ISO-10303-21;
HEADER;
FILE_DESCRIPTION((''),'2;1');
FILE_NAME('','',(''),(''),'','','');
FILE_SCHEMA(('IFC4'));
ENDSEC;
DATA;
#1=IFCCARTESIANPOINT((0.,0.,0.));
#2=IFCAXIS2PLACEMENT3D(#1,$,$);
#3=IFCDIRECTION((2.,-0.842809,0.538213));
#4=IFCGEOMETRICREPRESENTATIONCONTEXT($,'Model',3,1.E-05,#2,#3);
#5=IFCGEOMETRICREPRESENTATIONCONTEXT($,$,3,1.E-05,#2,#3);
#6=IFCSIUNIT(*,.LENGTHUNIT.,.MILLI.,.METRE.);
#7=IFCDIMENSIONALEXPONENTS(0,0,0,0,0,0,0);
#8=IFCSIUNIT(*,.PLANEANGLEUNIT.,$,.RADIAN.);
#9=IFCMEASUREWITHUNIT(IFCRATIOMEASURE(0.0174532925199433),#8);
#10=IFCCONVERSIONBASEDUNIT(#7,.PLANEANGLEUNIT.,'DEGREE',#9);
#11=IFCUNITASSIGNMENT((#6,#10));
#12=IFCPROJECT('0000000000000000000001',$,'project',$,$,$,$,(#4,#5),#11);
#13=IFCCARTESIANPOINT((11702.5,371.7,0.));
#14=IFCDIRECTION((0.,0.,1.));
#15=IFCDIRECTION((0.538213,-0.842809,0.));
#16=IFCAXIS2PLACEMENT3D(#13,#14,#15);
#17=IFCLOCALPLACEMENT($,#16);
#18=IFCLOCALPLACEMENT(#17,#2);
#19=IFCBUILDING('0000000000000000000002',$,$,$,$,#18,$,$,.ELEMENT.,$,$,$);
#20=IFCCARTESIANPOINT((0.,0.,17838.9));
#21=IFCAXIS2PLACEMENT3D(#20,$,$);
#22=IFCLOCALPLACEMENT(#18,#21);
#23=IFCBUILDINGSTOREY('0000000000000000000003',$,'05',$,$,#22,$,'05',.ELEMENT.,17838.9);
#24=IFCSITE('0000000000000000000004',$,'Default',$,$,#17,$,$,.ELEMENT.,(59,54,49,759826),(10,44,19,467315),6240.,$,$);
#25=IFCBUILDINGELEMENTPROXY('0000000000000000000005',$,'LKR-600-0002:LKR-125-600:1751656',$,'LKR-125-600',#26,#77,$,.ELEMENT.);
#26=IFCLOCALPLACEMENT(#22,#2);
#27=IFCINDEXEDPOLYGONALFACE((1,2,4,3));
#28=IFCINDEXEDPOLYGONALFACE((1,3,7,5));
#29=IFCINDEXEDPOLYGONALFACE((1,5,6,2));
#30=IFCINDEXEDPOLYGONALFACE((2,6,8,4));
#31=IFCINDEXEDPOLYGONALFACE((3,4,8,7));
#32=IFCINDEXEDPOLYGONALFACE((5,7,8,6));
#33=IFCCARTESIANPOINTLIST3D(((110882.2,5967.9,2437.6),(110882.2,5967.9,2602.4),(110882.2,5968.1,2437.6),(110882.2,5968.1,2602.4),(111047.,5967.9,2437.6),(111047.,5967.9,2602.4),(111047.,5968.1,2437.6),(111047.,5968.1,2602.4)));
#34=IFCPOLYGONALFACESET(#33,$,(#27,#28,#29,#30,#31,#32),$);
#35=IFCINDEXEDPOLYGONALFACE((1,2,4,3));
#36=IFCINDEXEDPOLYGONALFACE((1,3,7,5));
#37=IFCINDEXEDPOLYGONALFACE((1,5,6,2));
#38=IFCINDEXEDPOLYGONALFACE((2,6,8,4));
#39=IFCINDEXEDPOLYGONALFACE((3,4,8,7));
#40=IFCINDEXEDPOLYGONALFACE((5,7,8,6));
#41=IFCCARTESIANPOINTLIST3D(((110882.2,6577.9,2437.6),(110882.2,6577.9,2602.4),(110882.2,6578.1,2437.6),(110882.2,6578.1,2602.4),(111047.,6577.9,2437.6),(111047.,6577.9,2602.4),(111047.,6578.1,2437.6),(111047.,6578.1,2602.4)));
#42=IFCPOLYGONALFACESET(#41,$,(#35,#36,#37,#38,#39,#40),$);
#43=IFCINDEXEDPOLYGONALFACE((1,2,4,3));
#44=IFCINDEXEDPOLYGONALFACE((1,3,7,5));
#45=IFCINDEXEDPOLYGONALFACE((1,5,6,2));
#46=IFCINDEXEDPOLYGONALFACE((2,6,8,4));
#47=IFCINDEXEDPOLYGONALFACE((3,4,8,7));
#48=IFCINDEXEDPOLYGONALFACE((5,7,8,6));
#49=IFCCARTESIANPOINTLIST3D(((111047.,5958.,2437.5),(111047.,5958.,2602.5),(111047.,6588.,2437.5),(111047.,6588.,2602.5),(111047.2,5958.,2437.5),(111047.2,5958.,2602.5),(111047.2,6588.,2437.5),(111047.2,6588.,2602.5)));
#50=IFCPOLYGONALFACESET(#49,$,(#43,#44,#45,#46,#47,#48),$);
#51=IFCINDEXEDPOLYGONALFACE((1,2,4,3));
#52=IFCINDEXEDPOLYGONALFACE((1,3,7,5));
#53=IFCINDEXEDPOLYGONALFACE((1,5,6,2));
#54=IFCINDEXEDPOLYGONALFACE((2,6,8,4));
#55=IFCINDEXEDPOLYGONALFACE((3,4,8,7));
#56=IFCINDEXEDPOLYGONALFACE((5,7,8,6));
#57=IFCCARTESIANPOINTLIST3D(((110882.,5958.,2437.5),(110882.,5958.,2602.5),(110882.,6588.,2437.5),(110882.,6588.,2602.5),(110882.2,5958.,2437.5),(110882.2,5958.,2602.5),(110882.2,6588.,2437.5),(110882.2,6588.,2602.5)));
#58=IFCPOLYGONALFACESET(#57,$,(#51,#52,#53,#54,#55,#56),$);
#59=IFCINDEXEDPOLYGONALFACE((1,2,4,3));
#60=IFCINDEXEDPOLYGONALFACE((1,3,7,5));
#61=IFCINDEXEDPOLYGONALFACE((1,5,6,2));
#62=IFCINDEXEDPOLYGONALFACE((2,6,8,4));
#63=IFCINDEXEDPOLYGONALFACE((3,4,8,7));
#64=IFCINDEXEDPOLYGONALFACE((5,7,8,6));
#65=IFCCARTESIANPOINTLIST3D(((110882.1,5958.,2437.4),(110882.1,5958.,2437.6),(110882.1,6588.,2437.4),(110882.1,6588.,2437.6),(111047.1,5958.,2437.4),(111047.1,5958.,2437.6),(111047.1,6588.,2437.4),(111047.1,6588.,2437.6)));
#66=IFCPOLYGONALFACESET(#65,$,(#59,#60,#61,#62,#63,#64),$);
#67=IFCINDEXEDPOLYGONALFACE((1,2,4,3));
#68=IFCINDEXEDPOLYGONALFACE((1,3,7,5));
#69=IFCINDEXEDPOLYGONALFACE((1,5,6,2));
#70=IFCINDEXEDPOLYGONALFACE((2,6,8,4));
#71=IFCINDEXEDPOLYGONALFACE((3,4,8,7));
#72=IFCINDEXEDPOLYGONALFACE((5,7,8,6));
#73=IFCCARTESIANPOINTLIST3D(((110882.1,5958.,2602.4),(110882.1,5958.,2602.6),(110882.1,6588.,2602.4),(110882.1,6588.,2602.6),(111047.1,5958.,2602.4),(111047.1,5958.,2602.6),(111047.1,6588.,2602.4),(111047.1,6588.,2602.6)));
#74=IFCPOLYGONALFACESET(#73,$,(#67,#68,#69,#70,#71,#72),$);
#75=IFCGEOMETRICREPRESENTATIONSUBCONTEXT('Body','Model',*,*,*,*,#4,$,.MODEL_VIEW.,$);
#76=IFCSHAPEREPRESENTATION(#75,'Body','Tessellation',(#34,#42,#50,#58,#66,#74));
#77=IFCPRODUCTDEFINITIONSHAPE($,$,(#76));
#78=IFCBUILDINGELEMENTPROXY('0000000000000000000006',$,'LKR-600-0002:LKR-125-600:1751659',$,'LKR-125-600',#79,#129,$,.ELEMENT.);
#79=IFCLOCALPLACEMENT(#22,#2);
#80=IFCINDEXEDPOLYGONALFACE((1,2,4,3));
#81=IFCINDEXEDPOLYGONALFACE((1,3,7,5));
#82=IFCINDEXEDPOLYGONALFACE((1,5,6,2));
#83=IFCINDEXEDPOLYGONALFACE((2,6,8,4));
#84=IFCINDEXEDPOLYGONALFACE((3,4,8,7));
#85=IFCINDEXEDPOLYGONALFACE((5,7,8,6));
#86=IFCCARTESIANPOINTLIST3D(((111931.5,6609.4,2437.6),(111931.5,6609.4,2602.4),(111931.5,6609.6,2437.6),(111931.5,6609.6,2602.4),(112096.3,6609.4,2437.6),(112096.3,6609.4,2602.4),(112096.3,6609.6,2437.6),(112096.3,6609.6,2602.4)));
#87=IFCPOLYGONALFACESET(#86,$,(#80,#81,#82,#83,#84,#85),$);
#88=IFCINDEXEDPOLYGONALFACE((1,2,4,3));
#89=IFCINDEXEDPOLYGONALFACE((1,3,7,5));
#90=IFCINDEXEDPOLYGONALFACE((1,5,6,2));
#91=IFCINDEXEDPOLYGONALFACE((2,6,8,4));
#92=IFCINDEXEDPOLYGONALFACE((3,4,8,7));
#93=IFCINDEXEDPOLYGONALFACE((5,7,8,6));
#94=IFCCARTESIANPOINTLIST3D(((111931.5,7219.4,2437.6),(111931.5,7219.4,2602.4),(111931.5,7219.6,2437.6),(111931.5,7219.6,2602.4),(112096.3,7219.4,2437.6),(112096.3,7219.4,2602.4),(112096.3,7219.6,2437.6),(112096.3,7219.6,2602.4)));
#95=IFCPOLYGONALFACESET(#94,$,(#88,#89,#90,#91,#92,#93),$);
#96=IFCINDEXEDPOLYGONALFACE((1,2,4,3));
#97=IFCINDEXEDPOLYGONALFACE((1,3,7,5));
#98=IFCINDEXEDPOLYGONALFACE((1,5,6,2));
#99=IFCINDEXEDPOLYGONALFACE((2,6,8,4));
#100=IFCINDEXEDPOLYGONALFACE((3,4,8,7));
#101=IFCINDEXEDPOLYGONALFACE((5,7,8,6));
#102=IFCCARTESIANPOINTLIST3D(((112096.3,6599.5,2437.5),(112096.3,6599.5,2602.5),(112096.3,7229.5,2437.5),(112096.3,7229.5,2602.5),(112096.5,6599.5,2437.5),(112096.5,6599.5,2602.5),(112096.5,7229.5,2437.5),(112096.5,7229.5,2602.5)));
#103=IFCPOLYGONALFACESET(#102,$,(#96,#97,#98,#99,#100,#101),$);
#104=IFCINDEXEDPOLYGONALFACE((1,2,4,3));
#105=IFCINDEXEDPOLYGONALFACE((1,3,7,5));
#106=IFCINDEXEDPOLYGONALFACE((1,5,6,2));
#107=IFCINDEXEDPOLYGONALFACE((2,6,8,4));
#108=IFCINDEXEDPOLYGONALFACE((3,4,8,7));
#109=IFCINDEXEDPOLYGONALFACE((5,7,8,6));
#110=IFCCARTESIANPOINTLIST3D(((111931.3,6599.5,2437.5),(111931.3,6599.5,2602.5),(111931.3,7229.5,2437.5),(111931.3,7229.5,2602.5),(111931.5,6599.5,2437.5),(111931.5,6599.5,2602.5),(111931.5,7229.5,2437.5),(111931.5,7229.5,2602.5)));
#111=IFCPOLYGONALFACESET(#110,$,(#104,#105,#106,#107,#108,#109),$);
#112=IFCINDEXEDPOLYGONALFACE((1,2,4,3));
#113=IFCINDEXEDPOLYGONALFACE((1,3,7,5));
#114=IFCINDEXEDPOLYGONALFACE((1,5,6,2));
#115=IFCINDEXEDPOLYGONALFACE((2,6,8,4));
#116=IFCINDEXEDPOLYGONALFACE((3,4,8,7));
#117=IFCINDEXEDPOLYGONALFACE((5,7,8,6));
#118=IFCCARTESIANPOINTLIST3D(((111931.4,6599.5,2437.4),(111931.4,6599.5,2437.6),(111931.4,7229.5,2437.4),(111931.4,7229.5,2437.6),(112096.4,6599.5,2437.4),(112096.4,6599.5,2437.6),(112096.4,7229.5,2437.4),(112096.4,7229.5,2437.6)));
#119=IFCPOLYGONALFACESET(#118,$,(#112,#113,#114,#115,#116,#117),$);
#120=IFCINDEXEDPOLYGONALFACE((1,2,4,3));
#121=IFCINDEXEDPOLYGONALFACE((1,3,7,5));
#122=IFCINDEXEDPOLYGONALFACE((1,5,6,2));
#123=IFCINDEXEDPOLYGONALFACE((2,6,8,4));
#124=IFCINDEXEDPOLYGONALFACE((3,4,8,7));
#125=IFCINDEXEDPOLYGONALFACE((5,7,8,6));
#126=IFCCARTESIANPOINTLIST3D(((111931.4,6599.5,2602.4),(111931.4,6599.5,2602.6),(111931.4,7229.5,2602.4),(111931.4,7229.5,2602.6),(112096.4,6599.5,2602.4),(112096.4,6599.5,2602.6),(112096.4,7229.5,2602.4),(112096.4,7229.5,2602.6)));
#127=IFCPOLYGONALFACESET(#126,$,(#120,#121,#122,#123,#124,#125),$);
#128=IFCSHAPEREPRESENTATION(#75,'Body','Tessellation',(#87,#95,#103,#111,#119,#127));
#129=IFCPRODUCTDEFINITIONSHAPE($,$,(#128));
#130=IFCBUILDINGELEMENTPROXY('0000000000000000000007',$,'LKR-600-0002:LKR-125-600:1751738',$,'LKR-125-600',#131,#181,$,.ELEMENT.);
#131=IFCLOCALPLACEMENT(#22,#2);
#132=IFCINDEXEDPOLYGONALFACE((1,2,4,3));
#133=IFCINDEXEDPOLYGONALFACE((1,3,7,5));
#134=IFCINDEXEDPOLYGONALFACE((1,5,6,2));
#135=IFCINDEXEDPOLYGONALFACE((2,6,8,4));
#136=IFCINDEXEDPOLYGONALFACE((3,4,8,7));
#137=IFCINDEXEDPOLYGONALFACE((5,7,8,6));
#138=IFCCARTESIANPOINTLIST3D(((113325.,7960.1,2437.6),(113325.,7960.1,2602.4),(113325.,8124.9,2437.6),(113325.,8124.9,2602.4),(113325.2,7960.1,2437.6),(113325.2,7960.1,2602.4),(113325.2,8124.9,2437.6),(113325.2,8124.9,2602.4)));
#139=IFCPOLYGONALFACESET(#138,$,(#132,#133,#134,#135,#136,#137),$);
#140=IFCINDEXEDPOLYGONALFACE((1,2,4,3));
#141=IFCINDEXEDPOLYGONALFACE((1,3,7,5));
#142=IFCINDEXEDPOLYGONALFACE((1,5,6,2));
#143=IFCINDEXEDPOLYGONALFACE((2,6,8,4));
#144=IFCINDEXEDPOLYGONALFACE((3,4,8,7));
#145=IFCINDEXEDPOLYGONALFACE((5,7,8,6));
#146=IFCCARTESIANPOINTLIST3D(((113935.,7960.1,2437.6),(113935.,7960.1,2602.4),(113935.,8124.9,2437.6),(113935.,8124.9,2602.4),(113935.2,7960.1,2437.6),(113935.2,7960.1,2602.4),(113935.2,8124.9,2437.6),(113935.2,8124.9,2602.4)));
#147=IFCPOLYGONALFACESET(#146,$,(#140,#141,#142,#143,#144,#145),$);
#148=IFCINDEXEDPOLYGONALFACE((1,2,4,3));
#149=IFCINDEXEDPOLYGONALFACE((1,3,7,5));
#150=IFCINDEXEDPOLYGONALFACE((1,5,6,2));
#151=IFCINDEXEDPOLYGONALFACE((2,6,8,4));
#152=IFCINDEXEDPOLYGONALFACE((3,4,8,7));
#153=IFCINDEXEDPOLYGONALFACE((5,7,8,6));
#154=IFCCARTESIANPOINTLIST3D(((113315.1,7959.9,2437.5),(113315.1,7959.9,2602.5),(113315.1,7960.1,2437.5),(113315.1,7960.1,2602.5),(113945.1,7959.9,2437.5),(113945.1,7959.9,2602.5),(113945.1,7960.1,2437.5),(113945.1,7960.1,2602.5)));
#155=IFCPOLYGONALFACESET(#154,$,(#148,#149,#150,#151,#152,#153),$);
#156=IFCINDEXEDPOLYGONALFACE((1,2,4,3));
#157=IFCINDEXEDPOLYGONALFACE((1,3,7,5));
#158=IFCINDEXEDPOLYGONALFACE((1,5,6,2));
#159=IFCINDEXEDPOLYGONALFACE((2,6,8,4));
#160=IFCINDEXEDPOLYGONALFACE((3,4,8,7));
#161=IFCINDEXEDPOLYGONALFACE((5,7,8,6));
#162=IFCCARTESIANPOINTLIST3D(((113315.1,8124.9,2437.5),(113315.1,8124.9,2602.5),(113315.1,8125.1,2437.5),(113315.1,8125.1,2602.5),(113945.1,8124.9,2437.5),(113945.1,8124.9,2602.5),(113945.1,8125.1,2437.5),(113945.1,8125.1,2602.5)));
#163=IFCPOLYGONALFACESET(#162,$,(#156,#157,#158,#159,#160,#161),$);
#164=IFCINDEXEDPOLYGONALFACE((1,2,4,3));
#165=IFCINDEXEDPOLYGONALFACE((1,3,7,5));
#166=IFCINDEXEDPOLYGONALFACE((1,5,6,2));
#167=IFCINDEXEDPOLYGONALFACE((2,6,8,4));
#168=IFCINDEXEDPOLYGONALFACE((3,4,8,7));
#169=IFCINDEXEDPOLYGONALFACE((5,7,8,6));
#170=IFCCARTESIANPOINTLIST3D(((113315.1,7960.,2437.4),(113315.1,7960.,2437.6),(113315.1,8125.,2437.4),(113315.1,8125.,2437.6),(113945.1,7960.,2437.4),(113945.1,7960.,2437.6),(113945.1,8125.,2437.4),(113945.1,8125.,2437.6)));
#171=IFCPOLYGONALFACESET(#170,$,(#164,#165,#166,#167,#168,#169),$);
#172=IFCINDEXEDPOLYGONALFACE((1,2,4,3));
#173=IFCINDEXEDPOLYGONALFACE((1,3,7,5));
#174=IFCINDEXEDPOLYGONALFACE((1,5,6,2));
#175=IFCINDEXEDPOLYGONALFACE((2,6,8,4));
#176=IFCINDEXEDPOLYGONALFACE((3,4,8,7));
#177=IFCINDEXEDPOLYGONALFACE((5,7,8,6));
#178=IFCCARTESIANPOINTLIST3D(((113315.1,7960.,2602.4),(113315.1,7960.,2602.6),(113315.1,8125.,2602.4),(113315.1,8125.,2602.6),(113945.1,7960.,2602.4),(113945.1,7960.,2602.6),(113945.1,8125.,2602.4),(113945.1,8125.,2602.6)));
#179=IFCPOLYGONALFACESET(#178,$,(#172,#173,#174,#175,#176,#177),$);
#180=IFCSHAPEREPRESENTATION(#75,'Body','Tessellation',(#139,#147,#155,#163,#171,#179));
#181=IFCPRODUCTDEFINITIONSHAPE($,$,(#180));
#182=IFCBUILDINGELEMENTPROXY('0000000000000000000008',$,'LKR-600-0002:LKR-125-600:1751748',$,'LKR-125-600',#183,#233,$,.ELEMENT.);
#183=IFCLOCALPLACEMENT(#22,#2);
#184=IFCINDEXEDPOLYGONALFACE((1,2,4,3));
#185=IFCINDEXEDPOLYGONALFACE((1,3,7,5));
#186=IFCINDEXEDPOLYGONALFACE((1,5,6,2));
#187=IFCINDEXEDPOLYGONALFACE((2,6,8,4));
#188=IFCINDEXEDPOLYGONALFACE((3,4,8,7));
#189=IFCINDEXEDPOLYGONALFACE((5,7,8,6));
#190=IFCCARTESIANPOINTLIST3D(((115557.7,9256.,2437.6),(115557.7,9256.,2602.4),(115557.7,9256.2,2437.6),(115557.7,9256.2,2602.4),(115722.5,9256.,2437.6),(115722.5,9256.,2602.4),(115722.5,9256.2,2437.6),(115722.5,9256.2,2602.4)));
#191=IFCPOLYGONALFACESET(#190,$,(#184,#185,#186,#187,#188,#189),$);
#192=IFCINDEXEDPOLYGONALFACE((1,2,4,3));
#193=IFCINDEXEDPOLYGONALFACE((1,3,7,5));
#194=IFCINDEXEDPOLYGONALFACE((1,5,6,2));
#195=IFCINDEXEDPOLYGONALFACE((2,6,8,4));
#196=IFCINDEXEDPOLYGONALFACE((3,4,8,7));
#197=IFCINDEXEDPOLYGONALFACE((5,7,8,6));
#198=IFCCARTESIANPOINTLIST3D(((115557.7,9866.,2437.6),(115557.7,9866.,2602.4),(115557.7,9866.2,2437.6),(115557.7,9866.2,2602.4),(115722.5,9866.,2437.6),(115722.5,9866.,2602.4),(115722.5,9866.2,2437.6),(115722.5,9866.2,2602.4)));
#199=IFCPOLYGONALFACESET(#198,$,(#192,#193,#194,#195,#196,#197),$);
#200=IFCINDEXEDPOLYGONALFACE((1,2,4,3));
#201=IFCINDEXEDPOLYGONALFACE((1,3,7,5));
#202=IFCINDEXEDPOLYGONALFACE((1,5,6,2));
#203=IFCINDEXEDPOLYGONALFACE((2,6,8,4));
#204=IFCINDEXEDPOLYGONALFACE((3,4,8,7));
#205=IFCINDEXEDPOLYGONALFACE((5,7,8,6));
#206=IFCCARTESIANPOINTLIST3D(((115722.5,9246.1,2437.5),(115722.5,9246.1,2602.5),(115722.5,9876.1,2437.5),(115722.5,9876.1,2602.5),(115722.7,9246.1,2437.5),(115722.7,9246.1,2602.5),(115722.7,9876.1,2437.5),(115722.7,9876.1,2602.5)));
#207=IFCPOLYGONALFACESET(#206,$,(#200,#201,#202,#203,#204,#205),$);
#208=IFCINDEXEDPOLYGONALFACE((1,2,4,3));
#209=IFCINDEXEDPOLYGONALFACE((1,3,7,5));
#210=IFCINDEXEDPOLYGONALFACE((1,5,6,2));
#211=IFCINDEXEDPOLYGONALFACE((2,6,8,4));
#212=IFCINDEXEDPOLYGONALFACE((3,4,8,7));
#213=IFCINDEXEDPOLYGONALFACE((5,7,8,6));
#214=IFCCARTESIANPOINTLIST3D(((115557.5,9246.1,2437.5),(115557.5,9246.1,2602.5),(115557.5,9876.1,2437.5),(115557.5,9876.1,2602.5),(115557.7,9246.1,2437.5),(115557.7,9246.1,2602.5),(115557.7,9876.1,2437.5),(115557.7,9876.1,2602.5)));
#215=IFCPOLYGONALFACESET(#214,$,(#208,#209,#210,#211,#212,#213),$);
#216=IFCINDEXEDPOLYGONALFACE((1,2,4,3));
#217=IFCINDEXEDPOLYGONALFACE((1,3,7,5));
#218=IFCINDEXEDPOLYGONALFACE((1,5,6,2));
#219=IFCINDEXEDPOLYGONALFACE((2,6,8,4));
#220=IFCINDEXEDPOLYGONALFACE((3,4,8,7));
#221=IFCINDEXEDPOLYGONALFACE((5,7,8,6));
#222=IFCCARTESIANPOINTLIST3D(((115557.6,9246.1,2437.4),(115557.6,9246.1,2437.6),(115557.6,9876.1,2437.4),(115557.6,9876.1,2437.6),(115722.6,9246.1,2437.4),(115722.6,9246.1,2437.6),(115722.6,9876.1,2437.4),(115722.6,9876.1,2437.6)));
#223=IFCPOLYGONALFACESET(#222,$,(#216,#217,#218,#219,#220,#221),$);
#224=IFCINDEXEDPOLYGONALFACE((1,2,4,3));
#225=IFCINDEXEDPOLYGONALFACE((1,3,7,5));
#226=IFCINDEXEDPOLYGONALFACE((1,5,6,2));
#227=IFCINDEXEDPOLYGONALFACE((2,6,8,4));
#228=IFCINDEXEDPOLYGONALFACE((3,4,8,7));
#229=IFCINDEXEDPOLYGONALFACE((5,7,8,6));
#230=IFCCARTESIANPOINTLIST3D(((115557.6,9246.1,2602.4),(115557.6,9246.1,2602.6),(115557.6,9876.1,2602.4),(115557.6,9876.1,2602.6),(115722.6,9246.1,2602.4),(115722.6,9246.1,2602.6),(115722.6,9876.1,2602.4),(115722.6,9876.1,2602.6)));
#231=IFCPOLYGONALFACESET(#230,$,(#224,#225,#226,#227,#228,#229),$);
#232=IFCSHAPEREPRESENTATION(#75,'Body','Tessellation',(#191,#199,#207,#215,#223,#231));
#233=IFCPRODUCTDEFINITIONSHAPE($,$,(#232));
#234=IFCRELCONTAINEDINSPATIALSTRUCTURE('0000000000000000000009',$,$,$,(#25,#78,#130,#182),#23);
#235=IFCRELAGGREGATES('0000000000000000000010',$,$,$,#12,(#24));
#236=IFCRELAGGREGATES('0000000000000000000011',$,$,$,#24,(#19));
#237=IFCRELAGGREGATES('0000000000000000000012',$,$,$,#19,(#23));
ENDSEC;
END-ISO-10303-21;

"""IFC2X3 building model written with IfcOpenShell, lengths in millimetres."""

from ifc_helpers import new_model, entity, si_unit, converted_unit, direction, frame, frame_2d, origin, place, context, subcontext, project, spatial, rectangle, extrude, source, transform, mapped, element, save


model = new_model("IFC2X3")

# Units and contexts
model_context = context("Model", 3, precision=1e-05, world=origin(), true_north=direction((2.0, -0.842809, 0.538213)))
context_of_model = context(None, 3, precision=1e-05, world=origin(), true_north=direction((2.0, -0.842809, 0.538213)))
body_context = subcontext(model_context, "Body", "Model", "MODEL_VIEW")
ifc_project = project(units=[si_unit("LENGTHUNIT", "METRE", prefix="MILLI"), converted_unit("PLANEANGLEUNIT", "DEGREE", entity("IfcRatioMeasure", 0.0174532925199433), si_unit("PLANEANGLEUNIT", "RADIAN"), dimensions=[0, 0, 0, 0, 0, 0, 0])], contexts=[model_context, context_of_model])

# Site, building, storey
site_placement = place(None, frame((11702.5, 371.7, 0.0), z_axis=(0.0, 0.0, 1.0), x_axis=(0.538213, -0.842809, 0.0)))
site = spatial("IfcSite", under=ifc_project, at=site_placement, Name="Default", CompositionType="ELEMENT", RefLatitude=(59, 54, 49, 759826), RefLongitude=(10, 44, 19, 467315), RefElevation=6240.0)
building_placement = place(site_placement, origin())
building = spatial("IfcBuilding", under=site, at=building_placement, CompositionType="ELEMENT")
storey_placement = place(building_placement, frame((0.0, 0.0, 17838.9)))
storey = spatial("IfcBuildingStorey", under=building, at=storey_placement, Name="05", LongName="05", CompositionType="ELEMENT", Elevation=17838.9)

# Building element proxies
shared_shape_1 = source(origin(), body_context, "Body", "SweptSolid", [
    extrude(rectangle(XDim=0.2, YDim=164.8, at=frame_2d((0.0, 0.0), x_axis=(1.0, 0.0))), frame((305.0, 0.0, -82.4)), (0.0, 0.0, 1.0), 164.8),
    extrude(rectangle(XDim=0.2, YDim=164.8, at=frame_2d((0.0, 0.0), x_axis=(1.0, 0.0))), frame((-305.0, 0.0, -82.4)), (0.0, 0.0, 1.0), 164.8),
    extrude(rectangle(XDim=0.2, YDim=630.0, at=frame_2d((0.0, 0.0), x_axis=(1.0, 0.0))), frame((0.0, 82.5, -82.5), z_axis=(0.0, 0.0, 1.0), x_axis=(0.0, 1.0, 0.0)), (0.0, 0.0, 1.0), 165.0),
    extrude(rectangle(XDim=0.2, YDim=630.0, at=frame_2d((0.0, 0.0), x_axis=(1.0, 0.0))), frame((0.0, -82.5, -82.5), z_axis=(0.0, 0.0, 1.0), x_axis=(0.0, 1.0, 0.0)), (0.0, 0.0, 1.0), 165.0),
    extrude(rectangle(XDim=165.0, YDim=630.0, at=frame_2d((0.0, 0.0), x_axis=(1.0, 0.0))), frame((0.0, 0.0, -82.6), z_axis=(0.0, 0.0, 1.0), x_axis=(0.0, -1.0, 0.0)), (0.0, 0.0, 1.0), 0.2),
    extrude(rectangle(XDim=165.0, YDim=630.0, at=frame_2d((0.0, 0.0), x_axis=(1.0, 0.0))), frame((0.0, 0.0, 82.4), z_axis=(0.0, 0.0, 1.0), x_axis=(0.0, -1.0, 0.0)), (0.0, 0.0, 1.0), 0.2),
])
for number, where, z_axis, x_axis, name in (
    (1, (110964.6, 6273.0, 2520.0), (0.0, 0.0, 1.0), (0.0, -1.0, 0.0), "LKR-600-0002:LKR-125-600:1751656"),
    (2, (112013.9, 6914.5, 2520.0), (0.0, 0.0, 1.0), (-0.000003, -1.0, 0.0), "LKR-600-0002:LKR-125-600:1751659"),
    (3, (113630.1, 8042.5, 2520.0), (0.0, 0.0, 1.0), (-1.0, 0.0, 0.0), "LKR-600-0002:LKR-125-600:1751738"),
    (4, (115640.1, 9561.1, 2520.0), (0.0, 0.0, 1.0), (-0.000003, -1.0, 0.0), "LKR-600-0002:LKR-125-600:1751748"),
):
    element("IfcBuildingElementProxy", number, at=place(storey_placement, frame(where, z_axis=z_axis, x_axis=x_axis)), inside=storey, Name=name, ObjectType="LKR-125-600", CompositionType="ELEMENT", context=body_context, shape_type="MappedRepresentation", body=[
        mapped(shared_shape_1, transform((0.0, 0.0, 0.0), scale=1.0)),
    ])

save(model, "model.ifc")
